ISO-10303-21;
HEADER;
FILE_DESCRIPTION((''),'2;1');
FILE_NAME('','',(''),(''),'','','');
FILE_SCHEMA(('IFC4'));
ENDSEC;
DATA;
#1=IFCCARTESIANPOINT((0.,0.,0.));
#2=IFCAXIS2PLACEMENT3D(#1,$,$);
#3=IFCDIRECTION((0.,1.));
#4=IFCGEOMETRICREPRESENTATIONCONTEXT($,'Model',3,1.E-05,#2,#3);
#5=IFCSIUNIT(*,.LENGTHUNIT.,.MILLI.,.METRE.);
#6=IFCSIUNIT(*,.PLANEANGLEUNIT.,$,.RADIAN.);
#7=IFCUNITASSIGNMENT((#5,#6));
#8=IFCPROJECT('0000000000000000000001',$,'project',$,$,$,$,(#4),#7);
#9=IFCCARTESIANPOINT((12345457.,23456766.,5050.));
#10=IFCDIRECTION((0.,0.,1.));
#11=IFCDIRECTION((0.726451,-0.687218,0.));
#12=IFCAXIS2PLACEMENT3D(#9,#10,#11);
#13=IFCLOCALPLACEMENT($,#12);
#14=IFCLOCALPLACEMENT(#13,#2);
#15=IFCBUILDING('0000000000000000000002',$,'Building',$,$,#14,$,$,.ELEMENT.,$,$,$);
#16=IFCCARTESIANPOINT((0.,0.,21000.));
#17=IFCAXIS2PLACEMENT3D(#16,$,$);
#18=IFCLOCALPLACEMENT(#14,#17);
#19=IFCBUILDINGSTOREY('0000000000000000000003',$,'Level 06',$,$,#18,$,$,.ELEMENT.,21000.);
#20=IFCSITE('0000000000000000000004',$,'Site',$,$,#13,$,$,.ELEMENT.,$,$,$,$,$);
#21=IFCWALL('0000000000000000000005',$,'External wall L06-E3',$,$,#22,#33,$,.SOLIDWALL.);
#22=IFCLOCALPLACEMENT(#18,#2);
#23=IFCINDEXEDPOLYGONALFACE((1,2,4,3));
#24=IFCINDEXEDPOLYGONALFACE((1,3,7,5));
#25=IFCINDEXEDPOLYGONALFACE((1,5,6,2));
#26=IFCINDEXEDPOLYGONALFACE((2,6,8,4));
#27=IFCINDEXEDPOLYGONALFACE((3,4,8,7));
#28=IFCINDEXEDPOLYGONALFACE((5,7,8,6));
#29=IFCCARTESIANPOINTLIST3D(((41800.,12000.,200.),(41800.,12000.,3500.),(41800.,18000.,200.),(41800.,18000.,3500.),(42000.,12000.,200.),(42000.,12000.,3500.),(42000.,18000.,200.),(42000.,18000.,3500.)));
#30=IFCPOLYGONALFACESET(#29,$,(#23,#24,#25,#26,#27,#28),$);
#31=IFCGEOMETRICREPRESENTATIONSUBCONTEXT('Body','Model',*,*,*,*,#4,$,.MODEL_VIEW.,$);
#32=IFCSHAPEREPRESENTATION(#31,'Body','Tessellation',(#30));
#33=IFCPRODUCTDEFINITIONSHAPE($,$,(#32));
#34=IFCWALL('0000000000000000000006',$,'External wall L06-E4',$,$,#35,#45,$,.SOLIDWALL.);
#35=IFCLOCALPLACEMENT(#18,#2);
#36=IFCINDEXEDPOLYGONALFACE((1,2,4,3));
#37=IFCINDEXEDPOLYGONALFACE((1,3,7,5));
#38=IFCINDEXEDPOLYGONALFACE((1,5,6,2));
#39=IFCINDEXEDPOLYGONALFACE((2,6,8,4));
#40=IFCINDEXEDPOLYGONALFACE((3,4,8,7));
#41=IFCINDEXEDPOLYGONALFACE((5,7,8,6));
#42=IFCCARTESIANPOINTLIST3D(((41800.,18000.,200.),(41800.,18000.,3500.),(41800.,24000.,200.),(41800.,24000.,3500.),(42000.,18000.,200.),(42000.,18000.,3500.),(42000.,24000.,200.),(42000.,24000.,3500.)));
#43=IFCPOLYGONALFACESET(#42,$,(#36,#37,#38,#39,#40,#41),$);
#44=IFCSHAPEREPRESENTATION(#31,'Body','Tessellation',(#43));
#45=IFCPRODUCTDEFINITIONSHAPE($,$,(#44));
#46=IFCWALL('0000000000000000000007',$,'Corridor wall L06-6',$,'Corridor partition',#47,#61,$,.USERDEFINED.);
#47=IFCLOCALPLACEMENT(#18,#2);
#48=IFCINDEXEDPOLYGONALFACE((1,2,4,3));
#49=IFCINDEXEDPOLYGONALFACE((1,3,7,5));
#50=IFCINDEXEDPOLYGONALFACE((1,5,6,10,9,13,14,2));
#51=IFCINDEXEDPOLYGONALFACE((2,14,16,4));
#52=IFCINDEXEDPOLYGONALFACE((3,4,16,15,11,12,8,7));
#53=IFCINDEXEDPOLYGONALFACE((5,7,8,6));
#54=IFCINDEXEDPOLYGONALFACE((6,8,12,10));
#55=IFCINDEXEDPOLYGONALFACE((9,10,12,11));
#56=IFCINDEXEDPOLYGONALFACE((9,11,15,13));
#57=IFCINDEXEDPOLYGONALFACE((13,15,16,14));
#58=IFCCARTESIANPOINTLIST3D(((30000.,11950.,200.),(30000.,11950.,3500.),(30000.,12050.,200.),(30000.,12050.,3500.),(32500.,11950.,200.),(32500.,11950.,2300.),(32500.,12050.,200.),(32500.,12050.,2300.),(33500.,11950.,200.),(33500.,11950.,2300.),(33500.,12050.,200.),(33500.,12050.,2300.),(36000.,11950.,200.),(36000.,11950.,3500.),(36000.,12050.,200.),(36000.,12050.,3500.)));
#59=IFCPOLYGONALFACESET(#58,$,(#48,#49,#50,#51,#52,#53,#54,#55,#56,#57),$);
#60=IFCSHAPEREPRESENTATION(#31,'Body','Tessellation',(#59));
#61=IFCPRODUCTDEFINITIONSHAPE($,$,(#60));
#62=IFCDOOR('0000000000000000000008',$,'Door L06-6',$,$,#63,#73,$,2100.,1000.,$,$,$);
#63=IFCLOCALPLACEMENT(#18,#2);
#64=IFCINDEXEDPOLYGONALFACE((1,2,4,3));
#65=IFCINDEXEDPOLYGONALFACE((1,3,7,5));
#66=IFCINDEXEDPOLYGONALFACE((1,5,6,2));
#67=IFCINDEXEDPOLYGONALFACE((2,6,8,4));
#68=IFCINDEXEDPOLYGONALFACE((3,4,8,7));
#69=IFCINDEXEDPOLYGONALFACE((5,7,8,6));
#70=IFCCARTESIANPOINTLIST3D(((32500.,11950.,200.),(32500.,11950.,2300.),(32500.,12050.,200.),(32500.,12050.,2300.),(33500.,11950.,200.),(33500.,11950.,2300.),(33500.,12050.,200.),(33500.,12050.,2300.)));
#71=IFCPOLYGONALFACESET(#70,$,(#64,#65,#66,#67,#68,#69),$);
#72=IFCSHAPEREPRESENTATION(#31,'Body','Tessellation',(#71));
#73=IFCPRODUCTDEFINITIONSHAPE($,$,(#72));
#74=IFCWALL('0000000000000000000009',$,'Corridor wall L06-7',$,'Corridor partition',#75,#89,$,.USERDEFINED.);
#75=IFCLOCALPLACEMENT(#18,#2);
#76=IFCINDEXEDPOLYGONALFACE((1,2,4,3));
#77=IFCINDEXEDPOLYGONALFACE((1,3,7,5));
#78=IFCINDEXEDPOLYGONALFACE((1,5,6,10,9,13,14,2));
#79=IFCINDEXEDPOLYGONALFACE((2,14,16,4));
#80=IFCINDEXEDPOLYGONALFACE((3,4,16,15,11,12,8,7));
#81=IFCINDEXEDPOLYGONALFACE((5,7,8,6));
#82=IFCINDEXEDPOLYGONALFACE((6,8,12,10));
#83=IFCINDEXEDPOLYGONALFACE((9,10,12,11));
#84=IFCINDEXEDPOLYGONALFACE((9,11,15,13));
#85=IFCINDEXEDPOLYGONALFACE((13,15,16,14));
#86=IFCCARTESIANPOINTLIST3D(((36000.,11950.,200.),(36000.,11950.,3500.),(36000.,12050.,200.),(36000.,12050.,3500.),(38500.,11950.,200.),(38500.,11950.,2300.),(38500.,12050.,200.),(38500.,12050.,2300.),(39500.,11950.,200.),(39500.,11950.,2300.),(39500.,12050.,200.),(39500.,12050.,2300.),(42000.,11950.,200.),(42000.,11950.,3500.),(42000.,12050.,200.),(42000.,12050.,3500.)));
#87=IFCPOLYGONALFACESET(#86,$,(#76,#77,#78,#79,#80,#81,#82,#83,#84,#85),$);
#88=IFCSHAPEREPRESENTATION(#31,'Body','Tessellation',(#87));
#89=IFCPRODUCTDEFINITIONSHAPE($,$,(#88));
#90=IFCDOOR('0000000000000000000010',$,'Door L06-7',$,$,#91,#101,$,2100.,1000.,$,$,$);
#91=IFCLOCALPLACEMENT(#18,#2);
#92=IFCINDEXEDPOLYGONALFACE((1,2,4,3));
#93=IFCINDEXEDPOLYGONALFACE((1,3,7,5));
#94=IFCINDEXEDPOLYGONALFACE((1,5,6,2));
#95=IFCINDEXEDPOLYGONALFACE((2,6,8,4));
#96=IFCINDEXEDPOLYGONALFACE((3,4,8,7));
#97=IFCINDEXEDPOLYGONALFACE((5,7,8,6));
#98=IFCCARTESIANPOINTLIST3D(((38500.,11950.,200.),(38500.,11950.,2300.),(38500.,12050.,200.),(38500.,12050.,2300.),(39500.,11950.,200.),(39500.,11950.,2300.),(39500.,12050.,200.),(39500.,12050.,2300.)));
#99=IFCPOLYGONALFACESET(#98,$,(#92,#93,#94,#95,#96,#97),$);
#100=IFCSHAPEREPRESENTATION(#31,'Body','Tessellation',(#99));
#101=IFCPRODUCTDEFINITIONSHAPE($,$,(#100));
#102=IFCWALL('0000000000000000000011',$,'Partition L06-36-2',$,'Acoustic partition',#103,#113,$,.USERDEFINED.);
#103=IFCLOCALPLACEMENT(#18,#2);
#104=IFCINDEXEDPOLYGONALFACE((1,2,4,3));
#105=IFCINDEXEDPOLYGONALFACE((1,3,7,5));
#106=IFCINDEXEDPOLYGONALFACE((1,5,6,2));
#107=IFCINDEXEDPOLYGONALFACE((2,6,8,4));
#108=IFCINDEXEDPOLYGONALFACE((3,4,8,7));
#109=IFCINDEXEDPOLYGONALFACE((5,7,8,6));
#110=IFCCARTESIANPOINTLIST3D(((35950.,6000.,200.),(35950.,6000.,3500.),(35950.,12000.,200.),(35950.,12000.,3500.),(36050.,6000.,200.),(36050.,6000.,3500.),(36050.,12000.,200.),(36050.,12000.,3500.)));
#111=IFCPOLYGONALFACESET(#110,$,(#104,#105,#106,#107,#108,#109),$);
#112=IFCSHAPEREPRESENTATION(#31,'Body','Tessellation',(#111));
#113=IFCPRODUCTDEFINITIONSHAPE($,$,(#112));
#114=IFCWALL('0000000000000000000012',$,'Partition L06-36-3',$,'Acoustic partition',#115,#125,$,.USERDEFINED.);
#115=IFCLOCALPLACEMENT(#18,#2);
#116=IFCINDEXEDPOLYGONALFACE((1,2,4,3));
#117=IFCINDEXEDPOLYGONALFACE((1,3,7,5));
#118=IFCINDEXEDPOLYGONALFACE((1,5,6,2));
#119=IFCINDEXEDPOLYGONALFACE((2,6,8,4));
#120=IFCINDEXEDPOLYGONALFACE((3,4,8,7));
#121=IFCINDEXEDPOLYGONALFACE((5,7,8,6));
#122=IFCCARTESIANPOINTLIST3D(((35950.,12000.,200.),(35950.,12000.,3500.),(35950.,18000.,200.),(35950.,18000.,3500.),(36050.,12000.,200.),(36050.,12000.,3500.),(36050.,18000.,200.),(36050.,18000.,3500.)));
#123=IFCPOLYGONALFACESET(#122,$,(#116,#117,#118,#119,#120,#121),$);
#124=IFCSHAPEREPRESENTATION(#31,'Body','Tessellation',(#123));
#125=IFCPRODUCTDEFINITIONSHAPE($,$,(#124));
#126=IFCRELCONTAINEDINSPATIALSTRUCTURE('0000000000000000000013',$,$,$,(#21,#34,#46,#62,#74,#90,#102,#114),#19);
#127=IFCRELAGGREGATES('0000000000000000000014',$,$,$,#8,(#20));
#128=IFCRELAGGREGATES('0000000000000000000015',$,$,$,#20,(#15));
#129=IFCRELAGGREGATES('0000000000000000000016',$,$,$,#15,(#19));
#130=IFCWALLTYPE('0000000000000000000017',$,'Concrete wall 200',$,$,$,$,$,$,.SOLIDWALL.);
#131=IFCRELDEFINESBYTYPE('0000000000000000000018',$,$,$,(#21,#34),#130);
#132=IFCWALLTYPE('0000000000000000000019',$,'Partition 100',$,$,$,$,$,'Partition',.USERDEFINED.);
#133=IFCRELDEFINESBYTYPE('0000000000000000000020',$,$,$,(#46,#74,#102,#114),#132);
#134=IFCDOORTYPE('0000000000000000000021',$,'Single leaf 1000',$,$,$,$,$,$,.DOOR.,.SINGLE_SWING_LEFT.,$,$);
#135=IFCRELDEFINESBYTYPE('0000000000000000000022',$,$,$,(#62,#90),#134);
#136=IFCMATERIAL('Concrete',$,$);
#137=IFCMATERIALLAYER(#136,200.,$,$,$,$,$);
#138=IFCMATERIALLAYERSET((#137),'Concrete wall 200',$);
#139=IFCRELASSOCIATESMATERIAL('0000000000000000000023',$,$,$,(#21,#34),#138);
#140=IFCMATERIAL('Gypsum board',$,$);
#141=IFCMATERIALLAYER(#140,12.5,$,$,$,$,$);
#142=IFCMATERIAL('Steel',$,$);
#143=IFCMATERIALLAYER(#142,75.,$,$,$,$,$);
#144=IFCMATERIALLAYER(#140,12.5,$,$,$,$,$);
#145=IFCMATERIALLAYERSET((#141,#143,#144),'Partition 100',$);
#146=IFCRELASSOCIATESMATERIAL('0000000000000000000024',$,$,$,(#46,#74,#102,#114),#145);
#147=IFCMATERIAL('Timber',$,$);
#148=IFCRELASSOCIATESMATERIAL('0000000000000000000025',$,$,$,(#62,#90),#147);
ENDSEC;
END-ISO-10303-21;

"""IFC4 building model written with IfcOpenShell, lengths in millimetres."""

from ifc_helpers import new_model, si_unit, direction, frame, origin, place, context, subcontext, project, spatial, rectangle, extrude, source, transform, mapped, material, layer, layer_set, layer_usage, type_object, type_shapes, element, fill, save


model = new_model("IFC4")

# Units and contexts
model_context = context("Model", 3, precision=1e-05, world=origin(), true_north=direction((0.0, 1.0)))
body_context = subcontext(model_context, "Body", "Model", "MODEL_VIEW")
ifc_project = project(units=[si_unit("LENGTHUNIT", "METRE", prefix="MILLI"), si_unit("PLANEANGLEUNIT", "RADIAN")], contexts=[model_context])

# Site, building, storey
site_placement = place(None, frame((12345457.0, 23456766.0, 5050.0), z_axis=(0.0, 0.0, 1.0), x_axis=(0.726451, -0.687218, 0.0)))
site = spatial("IfcSite", under=ifc_project, at=site_placement, Name="Site", CompositionType="ELEMENT")
building_placement = place(site_placement, origin())
building = spatial("IfcBuilding", under=site, at=building_placement, Name="Building", CompositionType="ELEMENT")
storey_placement = place(building_placement, frame((0.0, 0.0, 21000.0)))
storey = spatial("IfcBuildingStorey", under=building, at=storey_placement, Name="Level 06", CompositionType="ELEMENT", Elevation=21000.0)

# Shared definitions
ifc_material_1 = material(Name="Steel")

# Shared definitions
ifc_material_2 = material(Name="Concrete")

# Walls
ifc_layer_1 = layer(ifc_material_2, 200.0)
ifc_layer_set_1 = layer_set([ifc_layer_1], Name="Concrete wall 200")
ifc_layer_usage_1 = layer_usage(ifc_layer_set_1, "AXIS2", "POSITIVE", 0.0)
wall_type_1 = type_object("IfcWallType", Name="Concrete wall 200", PredefinedType="SOLIDWALL")
for number, where, name in (
    (1, (41800.0, 12000.0, 200.0), "External wall L06-E3"),
    (2, (41800.0, 18000.0, 200.0), "External wall L06-E4"),
):
    element("IfcWall", number, at=place(storey_placement, frame(where)), inside=storey, type_object=wall_type_1, material=ifc_layer_usage_1, Name=name, PredefinedType="SOLIDWALL", context=body_context, shape_type="SweptSolid", body=[
        extrude(rectangle(XDim=200.0, YDim=6000.0), frame((100.0, 3000.0, 0.0)), (0.0, 0.0, 1.0), 3300.0),
    ])

# Walls, openings, doors
ifc_material_3 = material(Name="Gypsum board")
ifc_layer_2 = layer(ifc_material_3, 12.5)
ifc_layer_3 = layer(ifc_material_1, 75.0)
ifc_layer_4 = layer(ifc_material_3, 12.5)
ifc_layer_set_2 = layer_set([ifc_layer_2, ifc_layer_3, ifc_layer_4], Name="Partition 100")
ifc_layer_usage_2 = layer_usage(ifc_layer_set_2, "AXIS2", "POSITIVE", 0.0)
wall_type_2 = type_object("IfcWallType", Name="Partition 100", ElementType="Partition", PredefinedType="USERDEFINED")
wall_1_placement = place(storey_placement, frame((30000.0, 11950.0, 200.0)))
wall_1 = element("IfcWall", 3, at=wall_1_placement, inside=storey, type_object=wall_type_2, material=ifc_layer_usage_2, Name="Corridor wall L06-6", ObjectType="Corridor partition", PredefinedType="USERDEFINED", context=body_context, shape_type="SweptSolid", body=[
    extrude(rectangle(XDim=6000.0, YDim=100.0), frame((3000.0, 50.0, 0.0)), (0.0, 0.0, 1.0), 3300.0),
])
opening_1_placement = place(wall_1_placement, frame((2500.0, -50.0, 0.0)))
opening_1 = element("IfcOpeningElement", 4, at=opening_1_placement, cuts=wall_1, PredefinedType="OPENING", context=body_context, shape_type="SweptSolid", body=[
    extrude(rectangle(XDim=1000.0, YDim=200.0), frame((500.0, 100.0, 0.0)), (0.0, 0.0, 1.0), 2100.0),
])
ifc_material_4 = material(Name="Timber")
door_type = type_object("IfcDoorType", Name="Single leaf 1000", OperationType="SINGLE_SWING_LEFT", PredefinedType="DOOR")
shared_shape = source(origin(), body_context, "Body", "SweptSolid", [
    extrude(rectangle(XDim=1000.0, YDim=100.0), frame((500.0, 50.0, 0.0)), (0.0, 0.0, 1.0), 2100.0),
])
type_shapes(door_type, [shared_shape])
door_1_placement = place(storey_placement, frame((32500.0, 11950.0, 200.0)))
door_1 = element("IfcDoor", 5, at=door_1_placement, inside=storey, type_object=door_type, material=ifc_material_4, Name="Door L06-6", OverallHeight=2100.0, OverallWidth=1000.0, context=body_context, shape_type="MappedRepresentation", body=[
    mapped(shared_shape, transform((0.0, 0.0, 0.0))),
])
fill(opening_1, door_1)
wall_2_placement = place(storey_placement, frame((36000.0, 11950.0, 200.0)))
wall_2 = element("IfcWall", 6, at=wall_2_placement, inside=storey, type_object=wall_type_2, material=ifc_layer_usage_2, Name="Corridor wall L06-7", ObjectType="Corridor partition", PredefinedType="USERDEFINED", context=body_context, shape_type="SweptSolid", body=[
    extrude(rectangle(XDim=6000.0, YDim=100.0), frame((3000.0, 50.0, 0.0)), (0.0, 0.0, 1.0), 3300.0),
])
opening_2_placement = place(wall_2_placement, frame((2500.0, -50.0, 0.0)))
opening_2 = element("IfcOpeningElement", 7, at=opening_2_placement, cuts=wall_2, PredefinedType="OPENING", context=body_context, shape_type="SweptSolid", body=[
    extrude(rectangle(XDim=1000.0, YDim=200.0), frame((500.0, 100.0, 0.0)), (0.0, 0.0, 1.0), 2100.0),
])
door_2_placement = place(storey_placement, frame((38500.0, 11950.0, 200.0)))
door_2 = element("IfcDoor", 8, at=door_2_placement, inside=storey, type_object=door_type, material=ifc_material_4, Name="Door L06-7", OverallHeight=2100.0, OverallWidth=1000.0, context=body_context, shape_type="MappedRepresentation", body=[
    mapped(shared_shape, transform((0.0, 0.0, 0.0))),
])
fill(opening_2, door_2)

# Walls
for number, where, name in (
    (9, (35950.0, 6000.0, 200.0), "Partition L06-36-2"),
    (10, (35950.0, 12000.0, 200.0), "Partition L06-36-3"),
):
    element("IfcWall", number, at=place(storey_placement, frame(where)), inside=storey, type_object=wall_type_2, material=ifc_layer_usage_2, Name=name, ObjectType="Acoustic partition", PredefinedType="USERDEFINED", context=body_context, shape_type="SweptSolid", body=[
        extrude(rectangle(XDim=100.0, YDim=6000.0), frame((50.0, 3000.0, 0.0)), (0.0, 0.0, 1.0), 3300.0),
    ])

save(model, "model.ifc")
